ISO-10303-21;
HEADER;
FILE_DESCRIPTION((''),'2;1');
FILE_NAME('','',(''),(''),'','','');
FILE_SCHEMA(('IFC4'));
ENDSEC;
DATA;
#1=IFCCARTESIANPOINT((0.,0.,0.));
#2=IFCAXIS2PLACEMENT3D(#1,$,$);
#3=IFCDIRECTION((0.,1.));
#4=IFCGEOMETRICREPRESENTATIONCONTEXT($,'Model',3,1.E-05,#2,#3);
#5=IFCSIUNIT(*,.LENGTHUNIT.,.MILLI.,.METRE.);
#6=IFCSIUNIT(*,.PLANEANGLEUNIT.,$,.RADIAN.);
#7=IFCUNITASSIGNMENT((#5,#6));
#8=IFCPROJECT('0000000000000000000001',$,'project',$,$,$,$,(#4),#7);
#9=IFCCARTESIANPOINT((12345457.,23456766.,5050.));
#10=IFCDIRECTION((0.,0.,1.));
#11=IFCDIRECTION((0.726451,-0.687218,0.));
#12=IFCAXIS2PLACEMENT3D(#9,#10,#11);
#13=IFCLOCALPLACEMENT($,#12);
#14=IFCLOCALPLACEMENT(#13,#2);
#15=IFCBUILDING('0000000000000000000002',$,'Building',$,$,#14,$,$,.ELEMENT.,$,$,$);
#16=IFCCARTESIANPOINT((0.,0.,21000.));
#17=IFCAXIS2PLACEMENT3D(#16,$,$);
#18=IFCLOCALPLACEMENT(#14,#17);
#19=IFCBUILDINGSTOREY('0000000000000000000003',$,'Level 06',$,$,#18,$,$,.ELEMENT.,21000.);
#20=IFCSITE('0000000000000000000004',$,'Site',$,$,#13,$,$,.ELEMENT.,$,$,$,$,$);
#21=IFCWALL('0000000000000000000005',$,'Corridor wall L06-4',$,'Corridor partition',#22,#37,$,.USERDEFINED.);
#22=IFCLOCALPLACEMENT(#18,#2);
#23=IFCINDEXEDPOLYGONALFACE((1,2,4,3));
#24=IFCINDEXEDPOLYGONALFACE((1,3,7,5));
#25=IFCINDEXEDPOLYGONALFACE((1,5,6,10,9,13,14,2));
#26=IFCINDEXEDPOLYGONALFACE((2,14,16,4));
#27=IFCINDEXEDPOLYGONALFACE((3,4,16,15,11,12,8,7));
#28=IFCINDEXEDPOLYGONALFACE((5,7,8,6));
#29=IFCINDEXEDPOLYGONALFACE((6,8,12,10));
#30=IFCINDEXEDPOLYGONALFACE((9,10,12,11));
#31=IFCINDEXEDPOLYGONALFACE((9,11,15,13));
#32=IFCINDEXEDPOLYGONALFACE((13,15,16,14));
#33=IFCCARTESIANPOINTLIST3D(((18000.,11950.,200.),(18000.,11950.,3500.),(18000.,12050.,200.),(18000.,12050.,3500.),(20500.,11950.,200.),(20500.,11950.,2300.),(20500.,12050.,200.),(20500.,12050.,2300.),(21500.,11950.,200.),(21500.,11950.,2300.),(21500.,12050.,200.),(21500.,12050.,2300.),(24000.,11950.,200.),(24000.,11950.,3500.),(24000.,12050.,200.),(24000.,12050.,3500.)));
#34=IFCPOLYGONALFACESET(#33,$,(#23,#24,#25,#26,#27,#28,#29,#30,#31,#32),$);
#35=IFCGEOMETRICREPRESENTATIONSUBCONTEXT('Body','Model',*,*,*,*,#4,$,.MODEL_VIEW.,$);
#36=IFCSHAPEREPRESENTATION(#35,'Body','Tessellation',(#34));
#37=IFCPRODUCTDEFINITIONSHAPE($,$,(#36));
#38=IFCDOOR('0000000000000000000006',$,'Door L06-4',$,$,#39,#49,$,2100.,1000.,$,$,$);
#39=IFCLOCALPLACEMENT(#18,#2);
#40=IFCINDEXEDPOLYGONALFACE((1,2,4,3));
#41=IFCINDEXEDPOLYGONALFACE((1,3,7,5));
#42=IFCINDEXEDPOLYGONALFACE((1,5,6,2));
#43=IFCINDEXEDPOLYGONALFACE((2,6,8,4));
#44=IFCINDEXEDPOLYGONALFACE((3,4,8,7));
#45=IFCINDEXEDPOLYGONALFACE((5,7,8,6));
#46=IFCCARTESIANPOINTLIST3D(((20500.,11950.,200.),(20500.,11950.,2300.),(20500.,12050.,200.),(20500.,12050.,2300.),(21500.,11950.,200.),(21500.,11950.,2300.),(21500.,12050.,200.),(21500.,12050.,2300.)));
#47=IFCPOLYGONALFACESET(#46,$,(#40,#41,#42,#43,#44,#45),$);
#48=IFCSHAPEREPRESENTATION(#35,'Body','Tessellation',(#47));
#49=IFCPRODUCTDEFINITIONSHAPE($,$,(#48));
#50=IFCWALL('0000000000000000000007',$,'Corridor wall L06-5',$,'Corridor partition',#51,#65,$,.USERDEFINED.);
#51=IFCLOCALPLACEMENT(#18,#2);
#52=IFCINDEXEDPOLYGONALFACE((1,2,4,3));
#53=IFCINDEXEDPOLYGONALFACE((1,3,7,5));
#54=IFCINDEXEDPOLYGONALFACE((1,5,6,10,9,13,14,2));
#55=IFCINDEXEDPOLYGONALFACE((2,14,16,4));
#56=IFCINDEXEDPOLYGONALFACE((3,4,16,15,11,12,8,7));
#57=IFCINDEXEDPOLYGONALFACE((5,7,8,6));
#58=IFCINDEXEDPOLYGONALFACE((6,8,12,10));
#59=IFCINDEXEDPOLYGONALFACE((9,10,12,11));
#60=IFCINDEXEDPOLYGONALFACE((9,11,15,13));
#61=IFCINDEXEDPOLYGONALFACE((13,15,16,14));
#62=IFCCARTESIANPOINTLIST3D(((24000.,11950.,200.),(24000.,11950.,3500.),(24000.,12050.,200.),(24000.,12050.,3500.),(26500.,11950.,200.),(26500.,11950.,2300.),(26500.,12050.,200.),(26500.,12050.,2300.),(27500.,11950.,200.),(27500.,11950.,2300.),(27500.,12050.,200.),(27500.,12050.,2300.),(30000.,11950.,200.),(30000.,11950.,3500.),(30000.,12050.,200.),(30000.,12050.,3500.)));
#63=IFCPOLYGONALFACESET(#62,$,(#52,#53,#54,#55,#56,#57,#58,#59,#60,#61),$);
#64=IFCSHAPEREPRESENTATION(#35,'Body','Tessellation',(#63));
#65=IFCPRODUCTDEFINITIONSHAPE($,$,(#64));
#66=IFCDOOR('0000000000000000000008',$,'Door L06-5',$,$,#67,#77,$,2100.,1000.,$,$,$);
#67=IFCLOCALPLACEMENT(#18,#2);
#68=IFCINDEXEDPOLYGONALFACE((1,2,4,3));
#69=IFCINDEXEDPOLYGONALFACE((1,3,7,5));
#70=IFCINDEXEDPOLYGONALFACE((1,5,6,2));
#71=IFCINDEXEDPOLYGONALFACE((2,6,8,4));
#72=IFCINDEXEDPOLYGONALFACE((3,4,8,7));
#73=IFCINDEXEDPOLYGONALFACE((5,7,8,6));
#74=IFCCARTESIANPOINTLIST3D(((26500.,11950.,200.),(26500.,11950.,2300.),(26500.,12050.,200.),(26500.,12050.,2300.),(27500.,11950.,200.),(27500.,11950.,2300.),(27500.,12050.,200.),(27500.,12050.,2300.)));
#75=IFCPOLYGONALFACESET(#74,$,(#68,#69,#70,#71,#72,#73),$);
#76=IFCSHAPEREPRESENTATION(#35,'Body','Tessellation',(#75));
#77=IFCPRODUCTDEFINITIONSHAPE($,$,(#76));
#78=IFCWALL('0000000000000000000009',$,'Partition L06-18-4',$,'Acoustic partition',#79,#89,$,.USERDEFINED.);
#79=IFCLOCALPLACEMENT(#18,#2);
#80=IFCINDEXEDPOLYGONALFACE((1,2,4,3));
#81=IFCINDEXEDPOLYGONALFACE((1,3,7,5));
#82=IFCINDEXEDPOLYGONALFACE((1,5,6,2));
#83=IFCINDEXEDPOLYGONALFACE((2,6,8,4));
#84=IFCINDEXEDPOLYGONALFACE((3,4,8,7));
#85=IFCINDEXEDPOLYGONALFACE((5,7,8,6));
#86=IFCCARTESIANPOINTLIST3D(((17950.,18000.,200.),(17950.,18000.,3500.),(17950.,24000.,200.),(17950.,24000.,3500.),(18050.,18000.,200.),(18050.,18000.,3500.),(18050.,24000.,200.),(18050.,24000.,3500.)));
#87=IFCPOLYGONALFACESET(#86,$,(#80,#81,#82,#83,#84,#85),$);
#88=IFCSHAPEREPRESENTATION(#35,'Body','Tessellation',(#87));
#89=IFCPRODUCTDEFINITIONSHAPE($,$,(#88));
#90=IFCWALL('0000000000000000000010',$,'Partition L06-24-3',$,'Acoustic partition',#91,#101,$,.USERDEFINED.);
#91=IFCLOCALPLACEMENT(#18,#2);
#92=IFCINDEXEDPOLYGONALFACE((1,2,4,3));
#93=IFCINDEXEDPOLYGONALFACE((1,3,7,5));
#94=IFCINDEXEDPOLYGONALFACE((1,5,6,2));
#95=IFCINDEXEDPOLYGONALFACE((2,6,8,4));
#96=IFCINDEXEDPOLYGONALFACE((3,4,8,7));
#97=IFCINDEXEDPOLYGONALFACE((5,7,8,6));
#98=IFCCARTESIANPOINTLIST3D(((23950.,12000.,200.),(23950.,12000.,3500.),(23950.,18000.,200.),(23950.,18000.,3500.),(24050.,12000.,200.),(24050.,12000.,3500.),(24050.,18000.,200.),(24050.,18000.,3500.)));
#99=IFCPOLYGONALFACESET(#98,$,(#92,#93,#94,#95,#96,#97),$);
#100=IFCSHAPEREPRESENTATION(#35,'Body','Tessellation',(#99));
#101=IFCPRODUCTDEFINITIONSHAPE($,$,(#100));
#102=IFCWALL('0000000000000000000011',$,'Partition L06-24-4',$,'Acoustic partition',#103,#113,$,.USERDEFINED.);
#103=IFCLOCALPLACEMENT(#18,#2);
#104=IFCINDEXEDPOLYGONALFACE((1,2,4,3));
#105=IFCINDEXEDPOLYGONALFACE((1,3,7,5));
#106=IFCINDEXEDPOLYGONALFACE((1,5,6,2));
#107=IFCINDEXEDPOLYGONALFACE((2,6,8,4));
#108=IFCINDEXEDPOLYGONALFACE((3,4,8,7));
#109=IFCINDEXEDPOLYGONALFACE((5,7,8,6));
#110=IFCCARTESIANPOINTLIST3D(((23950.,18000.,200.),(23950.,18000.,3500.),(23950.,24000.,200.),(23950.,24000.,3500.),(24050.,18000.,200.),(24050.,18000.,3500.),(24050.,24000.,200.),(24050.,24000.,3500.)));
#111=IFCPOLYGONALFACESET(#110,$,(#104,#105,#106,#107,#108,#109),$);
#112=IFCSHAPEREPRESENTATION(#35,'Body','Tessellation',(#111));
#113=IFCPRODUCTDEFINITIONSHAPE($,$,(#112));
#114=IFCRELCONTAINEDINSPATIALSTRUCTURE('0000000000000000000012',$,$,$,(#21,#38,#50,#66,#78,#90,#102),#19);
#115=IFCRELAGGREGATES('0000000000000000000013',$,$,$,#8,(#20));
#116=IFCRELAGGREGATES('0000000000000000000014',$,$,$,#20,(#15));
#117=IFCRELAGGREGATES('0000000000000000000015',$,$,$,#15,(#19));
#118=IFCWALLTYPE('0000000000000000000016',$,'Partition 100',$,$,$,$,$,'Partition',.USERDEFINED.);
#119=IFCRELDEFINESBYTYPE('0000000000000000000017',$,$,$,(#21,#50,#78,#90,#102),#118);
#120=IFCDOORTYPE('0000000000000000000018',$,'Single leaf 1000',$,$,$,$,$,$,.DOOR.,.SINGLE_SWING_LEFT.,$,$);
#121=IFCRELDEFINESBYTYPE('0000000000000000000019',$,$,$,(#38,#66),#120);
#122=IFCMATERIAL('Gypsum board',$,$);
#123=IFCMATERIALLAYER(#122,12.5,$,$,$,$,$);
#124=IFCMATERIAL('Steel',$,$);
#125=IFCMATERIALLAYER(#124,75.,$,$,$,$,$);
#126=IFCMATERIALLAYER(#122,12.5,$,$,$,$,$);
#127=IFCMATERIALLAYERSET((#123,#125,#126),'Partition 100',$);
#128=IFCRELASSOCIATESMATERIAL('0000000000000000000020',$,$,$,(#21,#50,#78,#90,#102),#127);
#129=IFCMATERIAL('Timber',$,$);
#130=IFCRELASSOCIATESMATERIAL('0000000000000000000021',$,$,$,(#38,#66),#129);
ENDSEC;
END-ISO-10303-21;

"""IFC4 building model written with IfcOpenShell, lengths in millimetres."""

from ifc_helpers import new_model, si_unit, direction, frame, origin, place, context, subcontext, project, spatial, rectangle, extrude, source, transform, mapped, material, layer, layer_set, layer_usage, type_object, type_shapes, element, fill, save


model = new_model("IFC4")

# Units and contexts
model_context = context("Model", 3, precision=1e-05, world=origin(), true_north=direction((0.0, 1.0)))
body_context = subcontext(model_context, "Body", "Model", "MODEL_VIEW")
ifc_project = project(units=[si_unit("LENGTHUNIT", "METRE", prefix="MILLI"), si_unit("PLANEANGLEUNIT", "RADIAN")], contexts=[model_context])

# Site, building, storey
site_placement = place(None, frame((12345457.0, 23456766.0, 5050.0), z_axis=(0.0, 0.0, 1.0), x_axis=(0.726451, -0.687218, 0.0)))
site = spatial("IfcSite", under=ifc_project, at=site_placement, Name="Site", CompositionType="ELEMENT")
building_placement = place(site_placement, origin())
building = spatial("IfcBuilding", under=site, at=building_placement, Name="Building", CompositionType="ELEMENT")
storey_placement = place(building_placement, frame((0.0, 0.0, 21000.0)))
storey = spatial("IfcBuildingStorey", under=building, at=storey_placement, Name="Level 06", CompositionType="ELEMENT", Elevation=21000.0)

# Shared definitions
ifc_material_1 = material(Name="Steel")

# Walls, openings, doors
ifc_material_2 = material(Name="Gypsum board")
ifc_layer_1 = layer(ifc_material_2, 12.5)
ifc_layer_2 = layer(ifc_material_1, 75.0)
ifc_layer_3 = layer(ifc_material_2, 12.5)
ifc_layer_set_1 = layer_set([ifc_layer_1, ifc_layer_2, ifc_layer_3], Name="Partition 100")
ifc_layer_usage_1 = layer_usage(ifc_layer_set_1, "AXIS2", "POSITIVE", 0.0)
wall_type_1 = type_object("IfcWallType", Name="Partition 100", ElementType="Partition", PredefinedType="USERDEFINED")
wall_1_placement = place(storey_placement, frame((18000.0, 11950.0, 200.0)))
wall_1 = element("IfcWall", 1, at=wall_1_placement, inside=storey, type_object=wall_type_1, material=ifc_layer_usage_1, Name="Corridor wall L06-4", ObjectType="Corridor partition", PredefinedType="USERDEFINED", context=body_context, shape_type="SweptSolid", body=[
    extrude(rectangle(XDim=6000.0, YDim=100.0), frame((3000.0, 50.0, 0.0)), (0.0, 0.0, 1.0), 3300.0),
])
opening_1_placement = place(wall_1_placement, frame((2500.0, -50.0, 0.0)))
opening_1 = element("IfcOpeningElement", 2, at=opening_1_placement, cuts=wall_1, PredefinedType="OPENING", context=body_context, shape_type="SweptSolid", body=[
    extrude(rectangle(XDim=1000.0, YDim=200.0), frame((500.0, 100.0, 0.0)), (0.0, 0.0, 1.0), 2100.0),
])
ifc_material_3 = material(Name="Timber")
door_type = type_object("IfcDoorType", Name="Single leaf 1000", OperationType="SINGLE_SWING_LEFT", PredefinedType="DOOR")
shared_shape = source(origin(), body_context, "Body", "SweptSolid", [
    extrude(rectangle(XDim=1000.0, YDim=100.0), frame((500.0, 50.0, 0.0)), (0.0, 0.0, 1.0), 2100.0),
])
type_shapes(door_type, [shared_shape])
door_1_placement = place(storey_placement, frame((20500.0, 11950.0, 200.0)))
door_1 = element("IfcDoor", 3, at=door_1_placement, inside=storey, type_object=door_type, material=ifc_material_3, Name="Door L06-4", OverallHeight=2100.0, OverallWidth=1000.0, context=body_context, shape_type="MappedRepresentation", body=[
    mapped(shared_shape, transform((0.0, 0.0, 0.0))),
])
fill(opening_1, door_1)
wall_2_placement = place(storey_placement, frame((24000.0, 11950.0, 200.0)))
wall_2 = element("IfcWall", 4, at=wall_2_placement, inside=storey, type_object=wall_type_1, material=ifc_layer_usage_1, Name="Corridor wall L06-5", ObjectType="Corridor partition", PredefinedType="USERDEFINED", context=body_context, shape_type="SweptSolid", body=[
    extrude(rectangle(XDim=6000.0, YDim=100.0), frame((3000.0, 50.0, 0.0)), (0.0, 0.0, 1.0), 3300.0),
])
opening_2_placement = place(wall_2_placement, frame((2500.0, -50.0, 0.0)))
opening_2 = element("IfcOpeningElement", 5, at=opening_2_placement, cuts=wall_2, PredefinedType="OPENING", context=body_context, shape_type="SweptSolid", body=[
    extrude(rectangle(XDim=1000.0, YDim=200.0), frame((500.0, 100.0, 0.0)), (0.0, 0.0, 1.0), 2100.0),
])
door_2_placement = place(storey_placement, frame((26500.0, 11950.0, 200.0)))
door_2 = element("IfcDoor", 6, at=door_2_placement, inside=storey, type_object=door_type, material=ifc_material_3, Name="Door L06-5", OverallHeight=2100.0, OverallWidth=1000.0, context=body_context, shape_type="MappedRepresentation", body=[
    mapped(shared_shape, transform((0.0, 0.0, 0.0))),
])
fill(opening_2, door_2)

# Walls
for number, where, name in (
    (7, (17950.0, 18000.0, 200.0), "Partition L06-18-4"),
    (8, (23950.0, 12000.0, 200.0), "Partition L06-24-3"),
    (9, (23950.0, 18000.0, 200.0), "Partition L06-24-4"),
):
    element("IfcWall", number, at=place(storey_placement, frame(where)), inside=storey, type_object=wall_type_1, material=ifc_layer_usage_1, Name=name, ObjectType="Acoustic partition", PredefinedType="USERDEFINED", context=body_context, shape_type="SweptSolid", body=[
        extrude(rectangle(XDim=100.0, YDim=6000.0), frame((50.0, 3000.0, 0.0)), (0.0, 0.0, 1.0), 3300.0),
    ])

save(model, "model.ifc")
